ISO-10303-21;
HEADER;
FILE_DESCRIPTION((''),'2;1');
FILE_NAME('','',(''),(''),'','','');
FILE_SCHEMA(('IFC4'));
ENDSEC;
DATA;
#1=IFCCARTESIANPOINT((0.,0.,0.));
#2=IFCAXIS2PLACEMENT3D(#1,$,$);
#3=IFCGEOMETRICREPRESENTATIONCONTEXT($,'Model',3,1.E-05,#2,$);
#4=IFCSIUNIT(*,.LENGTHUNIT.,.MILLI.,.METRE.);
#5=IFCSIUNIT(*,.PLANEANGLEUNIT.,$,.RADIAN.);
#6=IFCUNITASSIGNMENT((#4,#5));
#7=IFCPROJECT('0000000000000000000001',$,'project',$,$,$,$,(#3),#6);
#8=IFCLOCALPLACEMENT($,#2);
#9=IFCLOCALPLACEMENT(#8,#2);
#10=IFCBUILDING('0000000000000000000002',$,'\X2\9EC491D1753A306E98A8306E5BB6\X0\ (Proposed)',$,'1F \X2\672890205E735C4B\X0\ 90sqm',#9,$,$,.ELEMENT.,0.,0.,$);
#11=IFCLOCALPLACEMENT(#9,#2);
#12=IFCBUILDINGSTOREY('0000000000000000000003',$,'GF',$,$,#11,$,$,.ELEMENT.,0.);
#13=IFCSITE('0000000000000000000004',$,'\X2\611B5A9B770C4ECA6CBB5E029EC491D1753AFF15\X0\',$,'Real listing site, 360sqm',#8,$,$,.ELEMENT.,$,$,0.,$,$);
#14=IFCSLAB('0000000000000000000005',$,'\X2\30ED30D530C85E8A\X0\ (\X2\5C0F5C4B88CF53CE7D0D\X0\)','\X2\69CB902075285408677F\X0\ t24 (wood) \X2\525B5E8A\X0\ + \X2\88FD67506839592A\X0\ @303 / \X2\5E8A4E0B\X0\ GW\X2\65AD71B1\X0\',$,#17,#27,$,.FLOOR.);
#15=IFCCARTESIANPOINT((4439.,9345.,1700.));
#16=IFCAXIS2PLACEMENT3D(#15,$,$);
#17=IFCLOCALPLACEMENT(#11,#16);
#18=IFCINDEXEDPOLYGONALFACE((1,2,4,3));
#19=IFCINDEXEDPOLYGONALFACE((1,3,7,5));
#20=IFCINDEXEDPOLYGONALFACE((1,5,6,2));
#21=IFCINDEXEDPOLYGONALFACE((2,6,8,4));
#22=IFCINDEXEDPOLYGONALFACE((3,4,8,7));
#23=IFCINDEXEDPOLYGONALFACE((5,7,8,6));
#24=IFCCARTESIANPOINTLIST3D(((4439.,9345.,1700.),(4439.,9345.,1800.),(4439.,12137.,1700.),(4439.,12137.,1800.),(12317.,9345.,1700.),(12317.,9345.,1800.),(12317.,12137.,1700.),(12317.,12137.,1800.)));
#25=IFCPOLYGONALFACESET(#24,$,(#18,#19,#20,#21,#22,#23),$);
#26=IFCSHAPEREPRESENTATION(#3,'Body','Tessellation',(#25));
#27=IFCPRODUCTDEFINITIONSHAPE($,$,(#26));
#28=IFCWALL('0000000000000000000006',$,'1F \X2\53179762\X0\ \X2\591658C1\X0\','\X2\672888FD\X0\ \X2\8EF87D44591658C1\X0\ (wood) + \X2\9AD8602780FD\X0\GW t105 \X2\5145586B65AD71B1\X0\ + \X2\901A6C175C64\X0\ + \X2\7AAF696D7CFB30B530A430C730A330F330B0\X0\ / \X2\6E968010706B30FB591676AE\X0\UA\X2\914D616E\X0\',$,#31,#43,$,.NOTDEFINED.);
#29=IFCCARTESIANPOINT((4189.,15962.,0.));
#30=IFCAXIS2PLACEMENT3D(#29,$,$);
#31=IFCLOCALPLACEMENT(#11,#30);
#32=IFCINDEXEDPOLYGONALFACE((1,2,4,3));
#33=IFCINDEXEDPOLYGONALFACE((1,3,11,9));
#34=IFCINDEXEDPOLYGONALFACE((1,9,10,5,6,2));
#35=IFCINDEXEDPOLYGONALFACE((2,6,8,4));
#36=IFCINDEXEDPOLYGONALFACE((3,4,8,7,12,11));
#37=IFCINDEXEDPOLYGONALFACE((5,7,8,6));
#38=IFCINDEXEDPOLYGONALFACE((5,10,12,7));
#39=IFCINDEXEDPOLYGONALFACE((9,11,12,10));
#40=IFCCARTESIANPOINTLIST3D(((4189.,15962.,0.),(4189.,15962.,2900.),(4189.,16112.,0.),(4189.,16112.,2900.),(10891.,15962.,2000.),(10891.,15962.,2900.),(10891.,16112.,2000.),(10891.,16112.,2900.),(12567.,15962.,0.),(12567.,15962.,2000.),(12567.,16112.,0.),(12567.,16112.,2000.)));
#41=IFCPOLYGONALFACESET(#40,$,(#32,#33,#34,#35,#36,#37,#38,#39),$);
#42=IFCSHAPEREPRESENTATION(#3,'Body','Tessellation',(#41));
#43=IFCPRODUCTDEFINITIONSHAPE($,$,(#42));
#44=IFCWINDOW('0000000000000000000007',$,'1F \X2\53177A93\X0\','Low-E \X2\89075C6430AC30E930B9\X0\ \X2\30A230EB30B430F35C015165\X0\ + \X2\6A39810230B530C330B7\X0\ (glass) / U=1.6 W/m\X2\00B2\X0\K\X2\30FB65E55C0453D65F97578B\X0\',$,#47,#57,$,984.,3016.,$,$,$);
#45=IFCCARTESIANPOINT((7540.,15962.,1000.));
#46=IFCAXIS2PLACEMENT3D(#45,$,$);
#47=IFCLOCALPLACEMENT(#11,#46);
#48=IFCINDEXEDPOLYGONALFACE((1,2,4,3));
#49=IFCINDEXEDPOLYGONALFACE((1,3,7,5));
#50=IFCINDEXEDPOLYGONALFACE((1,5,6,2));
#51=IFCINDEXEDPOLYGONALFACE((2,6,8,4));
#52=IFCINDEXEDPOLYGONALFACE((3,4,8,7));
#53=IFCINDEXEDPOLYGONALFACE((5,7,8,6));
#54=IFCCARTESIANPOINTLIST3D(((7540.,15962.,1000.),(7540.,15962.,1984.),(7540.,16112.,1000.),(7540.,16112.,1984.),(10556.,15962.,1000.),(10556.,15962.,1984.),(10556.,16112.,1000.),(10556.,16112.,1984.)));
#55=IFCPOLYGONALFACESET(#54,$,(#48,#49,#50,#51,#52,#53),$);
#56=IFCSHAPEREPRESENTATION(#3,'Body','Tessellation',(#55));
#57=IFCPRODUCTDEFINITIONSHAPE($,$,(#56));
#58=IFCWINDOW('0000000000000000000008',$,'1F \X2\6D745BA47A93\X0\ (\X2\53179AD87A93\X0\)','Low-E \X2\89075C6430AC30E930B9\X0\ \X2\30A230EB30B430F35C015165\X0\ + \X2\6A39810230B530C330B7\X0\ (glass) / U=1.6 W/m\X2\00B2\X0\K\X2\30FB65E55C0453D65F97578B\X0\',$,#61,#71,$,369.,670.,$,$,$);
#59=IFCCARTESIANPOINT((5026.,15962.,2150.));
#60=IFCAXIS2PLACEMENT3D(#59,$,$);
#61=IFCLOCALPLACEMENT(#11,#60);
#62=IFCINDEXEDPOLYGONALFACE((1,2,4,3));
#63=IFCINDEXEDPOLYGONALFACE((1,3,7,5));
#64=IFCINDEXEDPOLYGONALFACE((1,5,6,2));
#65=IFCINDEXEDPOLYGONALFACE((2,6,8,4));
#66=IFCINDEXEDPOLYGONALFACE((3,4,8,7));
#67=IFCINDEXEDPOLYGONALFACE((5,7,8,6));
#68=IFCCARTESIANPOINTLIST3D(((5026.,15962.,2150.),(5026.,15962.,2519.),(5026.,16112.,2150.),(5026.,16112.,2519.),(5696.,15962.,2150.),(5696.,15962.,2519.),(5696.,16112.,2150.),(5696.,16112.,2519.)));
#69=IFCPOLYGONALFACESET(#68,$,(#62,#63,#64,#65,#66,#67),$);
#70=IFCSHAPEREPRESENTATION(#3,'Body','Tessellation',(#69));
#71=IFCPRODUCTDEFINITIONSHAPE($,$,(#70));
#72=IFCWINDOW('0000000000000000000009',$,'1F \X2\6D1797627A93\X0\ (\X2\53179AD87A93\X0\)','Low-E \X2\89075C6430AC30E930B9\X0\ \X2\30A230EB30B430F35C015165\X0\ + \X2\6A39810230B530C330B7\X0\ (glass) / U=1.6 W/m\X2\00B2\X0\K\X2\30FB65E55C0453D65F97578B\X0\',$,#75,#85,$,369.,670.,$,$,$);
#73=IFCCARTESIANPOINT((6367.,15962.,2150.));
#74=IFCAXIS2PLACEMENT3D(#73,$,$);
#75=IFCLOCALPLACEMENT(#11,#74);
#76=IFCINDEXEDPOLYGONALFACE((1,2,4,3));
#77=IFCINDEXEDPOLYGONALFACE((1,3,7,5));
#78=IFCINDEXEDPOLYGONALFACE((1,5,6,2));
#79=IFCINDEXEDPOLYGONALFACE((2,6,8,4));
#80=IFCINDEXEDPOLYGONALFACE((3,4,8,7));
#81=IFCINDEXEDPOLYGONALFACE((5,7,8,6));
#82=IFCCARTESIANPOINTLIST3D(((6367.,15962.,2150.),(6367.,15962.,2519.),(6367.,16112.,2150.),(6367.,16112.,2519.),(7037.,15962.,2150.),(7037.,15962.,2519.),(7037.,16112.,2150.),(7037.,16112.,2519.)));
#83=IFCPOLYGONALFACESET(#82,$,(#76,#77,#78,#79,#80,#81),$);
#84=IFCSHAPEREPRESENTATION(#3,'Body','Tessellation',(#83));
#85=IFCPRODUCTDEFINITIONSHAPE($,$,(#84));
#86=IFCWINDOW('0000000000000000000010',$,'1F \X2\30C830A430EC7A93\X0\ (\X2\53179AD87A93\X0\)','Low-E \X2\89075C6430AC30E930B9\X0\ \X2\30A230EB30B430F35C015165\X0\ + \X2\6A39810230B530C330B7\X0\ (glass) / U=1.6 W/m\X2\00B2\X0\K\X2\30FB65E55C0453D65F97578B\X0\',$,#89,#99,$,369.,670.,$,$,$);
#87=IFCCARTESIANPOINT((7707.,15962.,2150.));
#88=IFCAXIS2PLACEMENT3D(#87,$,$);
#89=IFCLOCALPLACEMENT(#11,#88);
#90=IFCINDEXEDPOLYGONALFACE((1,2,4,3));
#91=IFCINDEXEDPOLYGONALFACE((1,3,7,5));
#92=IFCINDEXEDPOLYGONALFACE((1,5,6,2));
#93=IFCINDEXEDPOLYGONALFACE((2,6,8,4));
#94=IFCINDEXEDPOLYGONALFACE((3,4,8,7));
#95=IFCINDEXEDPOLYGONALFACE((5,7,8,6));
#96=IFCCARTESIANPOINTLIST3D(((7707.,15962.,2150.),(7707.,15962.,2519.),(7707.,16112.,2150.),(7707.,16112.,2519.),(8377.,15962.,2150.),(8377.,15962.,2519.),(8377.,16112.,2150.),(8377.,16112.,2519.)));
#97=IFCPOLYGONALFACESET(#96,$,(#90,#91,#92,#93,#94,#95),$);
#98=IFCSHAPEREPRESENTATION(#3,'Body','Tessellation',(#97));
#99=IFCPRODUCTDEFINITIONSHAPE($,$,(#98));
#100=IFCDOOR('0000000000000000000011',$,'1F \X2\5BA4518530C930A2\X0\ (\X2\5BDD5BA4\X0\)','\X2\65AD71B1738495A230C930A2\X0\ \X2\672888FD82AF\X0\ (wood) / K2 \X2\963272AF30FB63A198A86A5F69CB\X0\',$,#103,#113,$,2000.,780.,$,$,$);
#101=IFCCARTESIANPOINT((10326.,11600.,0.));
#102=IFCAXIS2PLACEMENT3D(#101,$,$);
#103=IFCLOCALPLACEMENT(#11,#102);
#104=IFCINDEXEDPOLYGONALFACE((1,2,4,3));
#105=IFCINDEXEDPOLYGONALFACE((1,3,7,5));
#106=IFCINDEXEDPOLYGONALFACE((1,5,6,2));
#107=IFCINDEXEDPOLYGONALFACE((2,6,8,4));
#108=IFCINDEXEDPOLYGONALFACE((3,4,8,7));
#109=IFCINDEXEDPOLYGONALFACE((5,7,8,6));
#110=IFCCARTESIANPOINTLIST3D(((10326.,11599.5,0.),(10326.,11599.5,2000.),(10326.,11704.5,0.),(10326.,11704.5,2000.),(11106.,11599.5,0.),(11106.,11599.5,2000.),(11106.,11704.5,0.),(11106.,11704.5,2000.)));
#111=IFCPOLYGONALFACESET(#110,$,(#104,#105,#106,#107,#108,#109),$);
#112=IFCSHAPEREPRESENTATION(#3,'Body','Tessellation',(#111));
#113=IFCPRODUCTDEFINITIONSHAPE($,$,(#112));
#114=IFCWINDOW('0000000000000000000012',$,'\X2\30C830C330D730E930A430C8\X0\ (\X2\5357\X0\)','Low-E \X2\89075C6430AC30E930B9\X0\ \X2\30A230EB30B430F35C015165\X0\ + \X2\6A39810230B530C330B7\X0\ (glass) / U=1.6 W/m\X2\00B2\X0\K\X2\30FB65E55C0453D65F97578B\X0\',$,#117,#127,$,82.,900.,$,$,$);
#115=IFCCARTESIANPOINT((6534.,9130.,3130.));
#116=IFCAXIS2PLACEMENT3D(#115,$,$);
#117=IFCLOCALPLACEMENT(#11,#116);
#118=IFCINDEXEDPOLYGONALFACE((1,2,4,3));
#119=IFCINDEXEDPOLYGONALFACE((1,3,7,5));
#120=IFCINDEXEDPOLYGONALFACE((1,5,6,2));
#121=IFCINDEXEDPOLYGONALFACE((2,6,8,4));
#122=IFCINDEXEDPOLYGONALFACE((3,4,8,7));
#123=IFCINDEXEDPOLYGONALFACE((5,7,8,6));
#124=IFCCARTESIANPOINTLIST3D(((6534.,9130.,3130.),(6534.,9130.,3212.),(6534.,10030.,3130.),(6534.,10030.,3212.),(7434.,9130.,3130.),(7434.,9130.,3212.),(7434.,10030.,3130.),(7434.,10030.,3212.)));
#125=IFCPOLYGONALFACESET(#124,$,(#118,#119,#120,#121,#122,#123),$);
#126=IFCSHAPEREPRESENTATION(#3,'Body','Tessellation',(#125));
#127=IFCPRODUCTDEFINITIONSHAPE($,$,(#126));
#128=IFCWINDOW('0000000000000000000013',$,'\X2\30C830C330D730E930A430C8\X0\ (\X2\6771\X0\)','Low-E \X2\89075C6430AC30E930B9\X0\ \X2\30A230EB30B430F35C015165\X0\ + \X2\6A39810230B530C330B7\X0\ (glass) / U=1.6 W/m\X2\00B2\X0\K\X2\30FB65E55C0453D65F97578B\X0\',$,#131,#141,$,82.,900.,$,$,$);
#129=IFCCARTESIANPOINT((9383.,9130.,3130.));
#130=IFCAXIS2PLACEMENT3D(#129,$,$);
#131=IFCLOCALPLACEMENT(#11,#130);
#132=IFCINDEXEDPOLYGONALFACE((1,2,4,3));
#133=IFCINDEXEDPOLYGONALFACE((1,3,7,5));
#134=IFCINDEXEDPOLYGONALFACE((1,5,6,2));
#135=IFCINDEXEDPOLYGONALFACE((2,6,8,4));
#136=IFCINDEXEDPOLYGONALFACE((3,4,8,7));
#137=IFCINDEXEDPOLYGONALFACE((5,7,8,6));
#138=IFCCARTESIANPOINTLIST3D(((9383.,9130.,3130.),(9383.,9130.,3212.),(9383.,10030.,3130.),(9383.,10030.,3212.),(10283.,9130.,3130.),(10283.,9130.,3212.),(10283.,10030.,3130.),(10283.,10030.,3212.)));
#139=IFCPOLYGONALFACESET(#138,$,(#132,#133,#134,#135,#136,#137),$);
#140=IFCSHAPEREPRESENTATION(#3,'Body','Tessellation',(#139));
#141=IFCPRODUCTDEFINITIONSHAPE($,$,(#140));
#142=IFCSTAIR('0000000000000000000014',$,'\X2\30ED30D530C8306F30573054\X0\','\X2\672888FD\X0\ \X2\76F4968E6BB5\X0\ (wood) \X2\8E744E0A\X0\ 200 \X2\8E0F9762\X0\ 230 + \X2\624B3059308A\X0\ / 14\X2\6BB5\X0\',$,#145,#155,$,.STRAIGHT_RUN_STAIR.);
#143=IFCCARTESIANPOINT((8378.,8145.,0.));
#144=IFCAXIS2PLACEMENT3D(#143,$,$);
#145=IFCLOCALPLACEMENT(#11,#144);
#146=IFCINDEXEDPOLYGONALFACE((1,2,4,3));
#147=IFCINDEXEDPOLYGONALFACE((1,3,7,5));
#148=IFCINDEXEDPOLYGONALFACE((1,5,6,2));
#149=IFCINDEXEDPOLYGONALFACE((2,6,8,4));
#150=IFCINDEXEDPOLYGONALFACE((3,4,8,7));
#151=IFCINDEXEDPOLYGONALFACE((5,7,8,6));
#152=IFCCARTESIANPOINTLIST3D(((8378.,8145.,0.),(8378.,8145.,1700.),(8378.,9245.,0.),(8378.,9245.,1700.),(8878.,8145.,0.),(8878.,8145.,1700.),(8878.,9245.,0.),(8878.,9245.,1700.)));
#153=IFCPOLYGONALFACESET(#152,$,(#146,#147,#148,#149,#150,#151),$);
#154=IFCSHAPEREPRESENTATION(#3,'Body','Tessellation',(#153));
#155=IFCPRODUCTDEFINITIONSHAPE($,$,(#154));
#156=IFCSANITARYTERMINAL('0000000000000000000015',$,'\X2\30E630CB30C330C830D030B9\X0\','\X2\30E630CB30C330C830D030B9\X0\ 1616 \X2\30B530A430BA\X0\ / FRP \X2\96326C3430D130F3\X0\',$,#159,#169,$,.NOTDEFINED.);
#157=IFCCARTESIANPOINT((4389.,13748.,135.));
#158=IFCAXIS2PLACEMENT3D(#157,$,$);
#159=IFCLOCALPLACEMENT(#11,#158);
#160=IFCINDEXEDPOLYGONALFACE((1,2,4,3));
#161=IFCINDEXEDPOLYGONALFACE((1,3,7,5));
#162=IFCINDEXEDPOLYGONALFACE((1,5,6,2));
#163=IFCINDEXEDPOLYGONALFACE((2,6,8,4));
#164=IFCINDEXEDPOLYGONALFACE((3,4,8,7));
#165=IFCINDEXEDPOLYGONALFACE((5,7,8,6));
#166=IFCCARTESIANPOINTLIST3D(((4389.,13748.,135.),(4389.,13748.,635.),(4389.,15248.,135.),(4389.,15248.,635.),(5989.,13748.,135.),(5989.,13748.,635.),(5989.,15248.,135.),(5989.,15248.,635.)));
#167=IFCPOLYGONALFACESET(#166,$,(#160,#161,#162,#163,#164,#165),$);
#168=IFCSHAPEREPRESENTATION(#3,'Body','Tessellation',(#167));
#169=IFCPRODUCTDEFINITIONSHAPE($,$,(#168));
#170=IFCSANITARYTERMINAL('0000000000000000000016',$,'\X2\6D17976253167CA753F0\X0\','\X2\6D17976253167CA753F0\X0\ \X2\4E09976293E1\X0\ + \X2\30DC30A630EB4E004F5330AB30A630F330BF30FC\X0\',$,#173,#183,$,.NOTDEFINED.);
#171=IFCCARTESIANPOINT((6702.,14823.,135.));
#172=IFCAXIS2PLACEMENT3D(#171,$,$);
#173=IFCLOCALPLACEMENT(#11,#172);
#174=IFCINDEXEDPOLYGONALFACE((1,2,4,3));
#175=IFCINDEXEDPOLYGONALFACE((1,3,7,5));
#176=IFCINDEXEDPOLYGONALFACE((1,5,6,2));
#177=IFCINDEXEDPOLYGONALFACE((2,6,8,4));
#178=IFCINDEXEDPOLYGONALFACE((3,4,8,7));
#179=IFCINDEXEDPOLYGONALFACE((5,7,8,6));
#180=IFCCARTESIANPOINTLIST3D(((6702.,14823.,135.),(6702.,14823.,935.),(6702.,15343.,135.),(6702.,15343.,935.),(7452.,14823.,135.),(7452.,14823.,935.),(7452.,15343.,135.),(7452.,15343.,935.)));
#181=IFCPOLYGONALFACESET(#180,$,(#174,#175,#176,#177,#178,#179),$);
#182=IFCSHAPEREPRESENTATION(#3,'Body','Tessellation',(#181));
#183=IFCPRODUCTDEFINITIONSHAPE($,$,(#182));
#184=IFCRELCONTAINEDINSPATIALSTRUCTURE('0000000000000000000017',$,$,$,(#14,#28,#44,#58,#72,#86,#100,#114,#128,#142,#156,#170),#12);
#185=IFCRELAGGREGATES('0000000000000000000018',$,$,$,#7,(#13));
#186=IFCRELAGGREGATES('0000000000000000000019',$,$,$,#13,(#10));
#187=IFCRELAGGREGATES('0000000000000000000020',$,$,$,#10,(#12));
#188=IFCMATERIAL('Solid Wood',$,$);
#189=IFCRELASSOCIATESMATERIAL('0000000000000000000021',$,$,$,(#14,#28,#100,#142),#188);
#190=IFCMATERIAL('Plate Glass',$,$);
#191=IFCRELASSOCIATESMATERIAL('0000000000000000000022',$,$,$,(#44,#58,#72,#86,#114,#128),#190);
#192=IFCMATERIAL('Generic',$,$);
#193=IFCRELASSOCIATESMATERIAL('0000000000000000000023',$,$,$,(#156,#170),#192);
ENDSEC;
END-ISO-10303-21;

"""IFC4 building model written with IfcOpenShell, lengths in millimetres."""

from ifc_helpers import new_model, si_unit, frame, frame_2d, origin, place, context, project, spatial, rectangle, extrude, material, element, fill, save


model = new_model("IFC4")

# Units and contexts
model_context = context("Model", 3, precision=1e-05, world=origin())
ifc_project = project(units=[si_unit("LENGTHUNIT", "METRE", prefix="MILLI"), si_unit("PLANEANGLEUNIT", "RADIAN")], contexts=[model_context])

# Site, building, storey
site_placement = place(None, origin())
site = spatial("IfcSite", under=ifc_project, at=site_placement, Name="愛媛県今治市黄金町５", ObjectType="Real listing site, 360sqm", CompositionType="ELEMENT", RefElevation=0.0)
building_placement = place(site_placement, origin())
building = spatial("IfcBuilding", under=site, at=building_placement, Name="黄金町の風の家 (Proposed)", ObjectType="1F 木造平屋 90sqm", CompositionType="ELEMENT", ElevationOfRefHeight=0.0, ElevationOfTerrain=0.0)
storey_placement = place(building_placement, origin())
storey = spatial("IfcBuildingStorey", under=building, at=storey_placement, Name="GF", CompositionType="ELEMENT", Elevation=0.0)

# Slab
ifc_material_1 = material(Name="Solid Wood")
slab_placement = place(storey_placement, frame((4439.0, 9345.0, 1700.0)))
element("IfcSlab", 1, at=slab_placement, inside=storey, material=ifc_material_1, Name="ロフト床 (小屋裏収納)", Description="構造用合板 t24 (wood) 剛床 + 製材根太 @303 / 床下 GW断熱", PredefinedType="FLOOR", context=model_context, shape_type="SweptSolid", body=[
    extrude(rectangle(XDim=7878.0, YDim=2792.0, at=frame_2d((3939.0, 1396.0))), frame((4439.0, 9345.0, 1700.0)), (0.0, 0.0, 1.0), 100.0),
])

# Wall, openings, windows
wall_1_placement = place(storey_placement, frame((4189.0, 15962.0, 0.0)))
wall_1 = element("IfcWall", 2, at=wall_1_placement, inside=storey, material=ifc_material_1, Name="1F 北面 外壁", Description="木製 軸組外壁 (wood) + 高性能GW t105 充填断熱 + 通気層 + 窯業系サイディング / 準耐火・外皮UA配慮", PredefinedType="NOTDEFINED", context=model_context, shape_type="SweptSolid", body=[
    extrude(rectangle(XDim=8378.0, YDim=150.0, at=frame_2d((4189.0, 75.0))), frame((4189.0, 15962.0, 0.0)), (0.0, 0.0, 1.0), 2900.0),
])
opening_1_placement = place(storey_placement, frame((7540.0, 15962.0, 1000.0)))
opening_1 = element("IfcOpeningElement", 3, at=opening_1_placement, cuts=wall_1, PredefinedType="NOTDEFINED", context=model_context, shape_type="SweptSolid", body=[
    extrude(rectangle(XDim=3016.0, YDim=150.0, at=frame_2d((1508.0, 75.0))), frame((7540.0, 15962.0, 1000.0)), (0.0, 0.0, 1.0), 984.0),
])
opening_2_placement = place(storey_placement, frame((5026.0, 15962.0, 2150.0)))
opening_2 = element("IfcOpeningElement", 4, at=opening_2_placement, cuts=wall_1, PredefinedType="NOTDEFINED", context=model_context, shape_type="SweptSolid", body=[
    extrude(rectangle(XDim=670.0, YDim=150.0, at=frame_2d((335.0, 75.0))), frame((5026.0, 15962.0, 2150.0)), (0.0, 0.0, 1.0), 369.0),
])
opening_3_placement = place(storey_placement, frame((6367.0, 15962.0, 2150.0)))
opening_3 = element("IfcOpeningElement", 5, at=opening_3_placement, cuts=wall_1, PredefinedType="NOTDEFINED", context=model_context, shape_type="SweptSolid", body=[
    extrude(rectangle(XDim=670.0, YDim=150.0, at=frame_2d((335.0, 75.0))), frame((6367.0, 15962.0, 2150.0)), (0.0, 0.0, 1.0), 369.0),
])
opening_4_placement = place(storey_placement, frame((7707.0, 15962.0, 2150.0)))
opening_4 = element("IfcOpeningElement", 6, at=opening_4_placement, cuts=wall_1, PredefinedType="NOTDEFINED", context=model_context, shape_type="SweptSolid", body=[
    extrude(rectangle(XDim=670.0, YDim=150.0, at=frame_2d((335.0, 75.0))), frame((7707.0, 15962.0, 2150.0)), (0.0, 0.0, 1.0), 369.0),
])
ifc_material_2 = material(Name="Plate Glass")
window_1_placement = place(storey_placement, frame((7540.0, 15962.0, 1000.0)))
window_1 = element("IfcWindow", 7, at=window_1_placement, inside=storey, material=ifc_material_2, Name="1F 北窓", Description="Low-E 複層ガラス アルゴン封入 + 樹脂サッシ (glass) / U=1.6 W/m²K・日射取得型", OverallHeight=984.0, OverallWidth=3016.0, context=model_context, shape_type="SweptSolid", body=[
    extrude(rectangle(XDim=3016.0, YDim=150.0, at=frame_2d((1508.0, 75.0))), frame((7540.0, 15962.0, 1000.0)), (0.0, 0.0, 1.0), 984.0),
])
fill(opening_1, window_1)
window_2_placement = place(storey_placement, frame((5026.0, 15962.0, 2150.0)))
window_2 = element("IfcWindow", 8, at=window_2_placement, inside=storey, material=ifc_material_2, Name="1F 浴室窓 (北高窓)", Description="Low-E 複層ガラス アルゴン封入 + 樹脂サッシ (glass) / U=1.6 W/m²K・日射取得型", OverallHeight=369.0, OverallWidth=670.0, context=model_context, shape_type="SweptSolid", body=[
    extrude(rectangle(XDim=670.0, YDim=150.0, at=frame_2d((335.0, 75.0))), frame((5026.0, 15962.0, 2150.0)), (0.0, 0.0, 1.0), 369.0),
])
fill(opening_2, window_2)
window_3_placement = place(storey_placement, frame((6367.0, 15962.0, 2150.0)))
window_3 = element("IfcWindow", 9, at=window_3_placement, inside=storey, material=ifc_material_2, Name="1F 洗面窓 (北高窓)", Description="Low-E 複層ガラス アルゴン封入 + 樹脂サッシ (glass) / U=1.6 W/m²K・日射取得型", OverallHeight=369.0, OverallWidth=670.0, context=model_context, shape_type="SweptSolid", body=[
    extrude(rectangle(XDim=670.0, YDim=150.0, at=frame_2d((335.0, 75.0))), frame((6367.0, 15962.0, 2150.0)), (0.0, 0.0, 1.0), 369.0),
])
fill(opening_3, window_3)
window_4_placement = place(storey_placement, frame((7707.0, 15962.0, 2150.0)))
window_4 = element("IfcWindow", 10, at=window_4_placement, inside=storey, material=ifc_material_2, Name="1F トイレ窓 (北高窓)", Description="Low-E 複層ガラス アルゴン封入 + 樹脂サッシ (glass) / U=1.6 W/m²K・日射取得型", OverallHeight=369.0, OverallWidth=670.0, context=model_context, shape_type="SweptSolid", body=[
    extrude(rectangle(XDim=670.0, YDim=150.0, at=frame_2d((335.0, 75.0))), frame((7707.0, 15962.0, 2150.0)), (0.0, 0.0, 1.0), 369.0),
])
fill(opening_4, window_4)

# Door
door_1_placement = place(storey_placement, frame((10326.0, 11600.0, 0.0)))
element("IfcDoor", 11, at=door_1_placement, inside=storey, material=ifc_material_1, Name="1F 室内ドア (寝室)", Description="断熱玄関ドア 木製芯 (wood) / K2 防犯・採風機構", OverallHeight=2000.0, OverallWidth=780.0, context=model_context, shape_type="SweptSolid", body=[
    extrude(rectangle(XDim=780.0, YDim=105.0, at=frame_2d((390.0, 52.0))), frame((10326.0, 11600.0, 0.0)), (0.0, 0.0, 1.0), 2000.0),
])

# Windows
window_5_placement = place(storey_placement, frame((6534.0, 9130.0, 3130.0)))
element("IfcWindow", 12, at=window_5_placement, inside=storey, material=ifc_material_2, Name="トップライト (南)", Description="Low-E 複層ガラス アルゴン封入 + 樹脂サッシ (glass) / U=1.6 W/m²K・日射取得型", OverallHeight=82.0, OverallWidth=900.0, context=model_context, shape_type="SweptSolid", body=[
    extrude(rectangle(XDim=900.0, YDim=900.0, at=frame_2d((450.0, 450.0))), frame((6534.0, 9130.0, 3130.0)), (0.0, 0.0, 1.0), 82.0),
])
window_6_placement = place(storey_placement, frame((9383.0, 9130.0, 3130.0)))
element("IfcWindow", 13, at=window_6_placement, inside=storey, material=ifc_material_2, Name="トップライト (東)", Description="Low-E 複層ガラス アルゴン封入 + 樹脂サッシ (glass) / U=1.6 W/m²K・日射取得型", OverallHeight=82.0, OverallWidth=900.0, context=model_context, shape_type="SweptSolid", body=[
    extrude(rectangle(XDim=900.0, YDim=900.0, at=frame_2d((450.0, 450.0))), frame((9383.0, 9130.0, 3130.0)), (0.0, 0.0, 1.0), 82.0),
])

# Stair
stair_placement = place(storey_placement, frame((8378.0, 8145.0, 0.0)))
element("IfcStair", 14, at=stair_placement, inside=storey, material=ifc_material_1, Name="ロフトはしご", Description="木製 直階段 (wood) 蹴上 200 踏面 230 + 手すり / 14段", PredefinedType="STRAIGHT_RUN_STAIR", context=model_context, shape_type="SweptSolid", body=[
    extrude(rectangle(XDim=500.0, YDim=1100.0, at=frame_2d((250.0, 550.0))), frame((8378.0, 8145.0, 0.0)), (0.0, 0.0, 1.0), 1700.0),
])

# Sanitary terminals
ifc_material_3 = material(Name="Generic")
sanitary_terminal_1_placement = place(storey_placement, frame((4389.0, 13748.0, 135.0)))
element("IfcSanitaryTerminal", 15, at=sanitary_terminal_1_placement, inside=storey, material=ifc_material_3, Name="ユニットバス", Description="ユニットバス 1616 サイズ / FRP 防水パン", PredefinedType="NOTDEFINED", context=model_context, shape_type="SweptSolid", body=[
    extrude(rectangle(XDim=1600.0, YDim=1500.0, at=frame_2d((800.0, 750.0))), frame((4389.0, 13748.0, 135.0)), (0.0, 0.0, 1.0), 500.0),
])
sanitary_terminal_2_placement = place(storey_placement, frame((6702.0, 14823.0, 135.0)))
element("IfcSanitaryTerminal", 16, at=sanitary_terminal_2_placement, inside=storey, material=ifc_material_3, Name="洗面化粧台", Description="洗面化粧台 三面鏡 + ボウル一体カウンター", PredefinedType="NOTDEFINED", context=model_context, shape_type="SweptSolid", body=[
    extrude(rectangle(XDim=750.0, YDim=520.0, at=frame_2d((375.0, 260.0))), frame((6702.0, 14823.0, 135.0)), (0.0, 0.0, 1.0), 800.0),
])

save(model, "model.ifc")
